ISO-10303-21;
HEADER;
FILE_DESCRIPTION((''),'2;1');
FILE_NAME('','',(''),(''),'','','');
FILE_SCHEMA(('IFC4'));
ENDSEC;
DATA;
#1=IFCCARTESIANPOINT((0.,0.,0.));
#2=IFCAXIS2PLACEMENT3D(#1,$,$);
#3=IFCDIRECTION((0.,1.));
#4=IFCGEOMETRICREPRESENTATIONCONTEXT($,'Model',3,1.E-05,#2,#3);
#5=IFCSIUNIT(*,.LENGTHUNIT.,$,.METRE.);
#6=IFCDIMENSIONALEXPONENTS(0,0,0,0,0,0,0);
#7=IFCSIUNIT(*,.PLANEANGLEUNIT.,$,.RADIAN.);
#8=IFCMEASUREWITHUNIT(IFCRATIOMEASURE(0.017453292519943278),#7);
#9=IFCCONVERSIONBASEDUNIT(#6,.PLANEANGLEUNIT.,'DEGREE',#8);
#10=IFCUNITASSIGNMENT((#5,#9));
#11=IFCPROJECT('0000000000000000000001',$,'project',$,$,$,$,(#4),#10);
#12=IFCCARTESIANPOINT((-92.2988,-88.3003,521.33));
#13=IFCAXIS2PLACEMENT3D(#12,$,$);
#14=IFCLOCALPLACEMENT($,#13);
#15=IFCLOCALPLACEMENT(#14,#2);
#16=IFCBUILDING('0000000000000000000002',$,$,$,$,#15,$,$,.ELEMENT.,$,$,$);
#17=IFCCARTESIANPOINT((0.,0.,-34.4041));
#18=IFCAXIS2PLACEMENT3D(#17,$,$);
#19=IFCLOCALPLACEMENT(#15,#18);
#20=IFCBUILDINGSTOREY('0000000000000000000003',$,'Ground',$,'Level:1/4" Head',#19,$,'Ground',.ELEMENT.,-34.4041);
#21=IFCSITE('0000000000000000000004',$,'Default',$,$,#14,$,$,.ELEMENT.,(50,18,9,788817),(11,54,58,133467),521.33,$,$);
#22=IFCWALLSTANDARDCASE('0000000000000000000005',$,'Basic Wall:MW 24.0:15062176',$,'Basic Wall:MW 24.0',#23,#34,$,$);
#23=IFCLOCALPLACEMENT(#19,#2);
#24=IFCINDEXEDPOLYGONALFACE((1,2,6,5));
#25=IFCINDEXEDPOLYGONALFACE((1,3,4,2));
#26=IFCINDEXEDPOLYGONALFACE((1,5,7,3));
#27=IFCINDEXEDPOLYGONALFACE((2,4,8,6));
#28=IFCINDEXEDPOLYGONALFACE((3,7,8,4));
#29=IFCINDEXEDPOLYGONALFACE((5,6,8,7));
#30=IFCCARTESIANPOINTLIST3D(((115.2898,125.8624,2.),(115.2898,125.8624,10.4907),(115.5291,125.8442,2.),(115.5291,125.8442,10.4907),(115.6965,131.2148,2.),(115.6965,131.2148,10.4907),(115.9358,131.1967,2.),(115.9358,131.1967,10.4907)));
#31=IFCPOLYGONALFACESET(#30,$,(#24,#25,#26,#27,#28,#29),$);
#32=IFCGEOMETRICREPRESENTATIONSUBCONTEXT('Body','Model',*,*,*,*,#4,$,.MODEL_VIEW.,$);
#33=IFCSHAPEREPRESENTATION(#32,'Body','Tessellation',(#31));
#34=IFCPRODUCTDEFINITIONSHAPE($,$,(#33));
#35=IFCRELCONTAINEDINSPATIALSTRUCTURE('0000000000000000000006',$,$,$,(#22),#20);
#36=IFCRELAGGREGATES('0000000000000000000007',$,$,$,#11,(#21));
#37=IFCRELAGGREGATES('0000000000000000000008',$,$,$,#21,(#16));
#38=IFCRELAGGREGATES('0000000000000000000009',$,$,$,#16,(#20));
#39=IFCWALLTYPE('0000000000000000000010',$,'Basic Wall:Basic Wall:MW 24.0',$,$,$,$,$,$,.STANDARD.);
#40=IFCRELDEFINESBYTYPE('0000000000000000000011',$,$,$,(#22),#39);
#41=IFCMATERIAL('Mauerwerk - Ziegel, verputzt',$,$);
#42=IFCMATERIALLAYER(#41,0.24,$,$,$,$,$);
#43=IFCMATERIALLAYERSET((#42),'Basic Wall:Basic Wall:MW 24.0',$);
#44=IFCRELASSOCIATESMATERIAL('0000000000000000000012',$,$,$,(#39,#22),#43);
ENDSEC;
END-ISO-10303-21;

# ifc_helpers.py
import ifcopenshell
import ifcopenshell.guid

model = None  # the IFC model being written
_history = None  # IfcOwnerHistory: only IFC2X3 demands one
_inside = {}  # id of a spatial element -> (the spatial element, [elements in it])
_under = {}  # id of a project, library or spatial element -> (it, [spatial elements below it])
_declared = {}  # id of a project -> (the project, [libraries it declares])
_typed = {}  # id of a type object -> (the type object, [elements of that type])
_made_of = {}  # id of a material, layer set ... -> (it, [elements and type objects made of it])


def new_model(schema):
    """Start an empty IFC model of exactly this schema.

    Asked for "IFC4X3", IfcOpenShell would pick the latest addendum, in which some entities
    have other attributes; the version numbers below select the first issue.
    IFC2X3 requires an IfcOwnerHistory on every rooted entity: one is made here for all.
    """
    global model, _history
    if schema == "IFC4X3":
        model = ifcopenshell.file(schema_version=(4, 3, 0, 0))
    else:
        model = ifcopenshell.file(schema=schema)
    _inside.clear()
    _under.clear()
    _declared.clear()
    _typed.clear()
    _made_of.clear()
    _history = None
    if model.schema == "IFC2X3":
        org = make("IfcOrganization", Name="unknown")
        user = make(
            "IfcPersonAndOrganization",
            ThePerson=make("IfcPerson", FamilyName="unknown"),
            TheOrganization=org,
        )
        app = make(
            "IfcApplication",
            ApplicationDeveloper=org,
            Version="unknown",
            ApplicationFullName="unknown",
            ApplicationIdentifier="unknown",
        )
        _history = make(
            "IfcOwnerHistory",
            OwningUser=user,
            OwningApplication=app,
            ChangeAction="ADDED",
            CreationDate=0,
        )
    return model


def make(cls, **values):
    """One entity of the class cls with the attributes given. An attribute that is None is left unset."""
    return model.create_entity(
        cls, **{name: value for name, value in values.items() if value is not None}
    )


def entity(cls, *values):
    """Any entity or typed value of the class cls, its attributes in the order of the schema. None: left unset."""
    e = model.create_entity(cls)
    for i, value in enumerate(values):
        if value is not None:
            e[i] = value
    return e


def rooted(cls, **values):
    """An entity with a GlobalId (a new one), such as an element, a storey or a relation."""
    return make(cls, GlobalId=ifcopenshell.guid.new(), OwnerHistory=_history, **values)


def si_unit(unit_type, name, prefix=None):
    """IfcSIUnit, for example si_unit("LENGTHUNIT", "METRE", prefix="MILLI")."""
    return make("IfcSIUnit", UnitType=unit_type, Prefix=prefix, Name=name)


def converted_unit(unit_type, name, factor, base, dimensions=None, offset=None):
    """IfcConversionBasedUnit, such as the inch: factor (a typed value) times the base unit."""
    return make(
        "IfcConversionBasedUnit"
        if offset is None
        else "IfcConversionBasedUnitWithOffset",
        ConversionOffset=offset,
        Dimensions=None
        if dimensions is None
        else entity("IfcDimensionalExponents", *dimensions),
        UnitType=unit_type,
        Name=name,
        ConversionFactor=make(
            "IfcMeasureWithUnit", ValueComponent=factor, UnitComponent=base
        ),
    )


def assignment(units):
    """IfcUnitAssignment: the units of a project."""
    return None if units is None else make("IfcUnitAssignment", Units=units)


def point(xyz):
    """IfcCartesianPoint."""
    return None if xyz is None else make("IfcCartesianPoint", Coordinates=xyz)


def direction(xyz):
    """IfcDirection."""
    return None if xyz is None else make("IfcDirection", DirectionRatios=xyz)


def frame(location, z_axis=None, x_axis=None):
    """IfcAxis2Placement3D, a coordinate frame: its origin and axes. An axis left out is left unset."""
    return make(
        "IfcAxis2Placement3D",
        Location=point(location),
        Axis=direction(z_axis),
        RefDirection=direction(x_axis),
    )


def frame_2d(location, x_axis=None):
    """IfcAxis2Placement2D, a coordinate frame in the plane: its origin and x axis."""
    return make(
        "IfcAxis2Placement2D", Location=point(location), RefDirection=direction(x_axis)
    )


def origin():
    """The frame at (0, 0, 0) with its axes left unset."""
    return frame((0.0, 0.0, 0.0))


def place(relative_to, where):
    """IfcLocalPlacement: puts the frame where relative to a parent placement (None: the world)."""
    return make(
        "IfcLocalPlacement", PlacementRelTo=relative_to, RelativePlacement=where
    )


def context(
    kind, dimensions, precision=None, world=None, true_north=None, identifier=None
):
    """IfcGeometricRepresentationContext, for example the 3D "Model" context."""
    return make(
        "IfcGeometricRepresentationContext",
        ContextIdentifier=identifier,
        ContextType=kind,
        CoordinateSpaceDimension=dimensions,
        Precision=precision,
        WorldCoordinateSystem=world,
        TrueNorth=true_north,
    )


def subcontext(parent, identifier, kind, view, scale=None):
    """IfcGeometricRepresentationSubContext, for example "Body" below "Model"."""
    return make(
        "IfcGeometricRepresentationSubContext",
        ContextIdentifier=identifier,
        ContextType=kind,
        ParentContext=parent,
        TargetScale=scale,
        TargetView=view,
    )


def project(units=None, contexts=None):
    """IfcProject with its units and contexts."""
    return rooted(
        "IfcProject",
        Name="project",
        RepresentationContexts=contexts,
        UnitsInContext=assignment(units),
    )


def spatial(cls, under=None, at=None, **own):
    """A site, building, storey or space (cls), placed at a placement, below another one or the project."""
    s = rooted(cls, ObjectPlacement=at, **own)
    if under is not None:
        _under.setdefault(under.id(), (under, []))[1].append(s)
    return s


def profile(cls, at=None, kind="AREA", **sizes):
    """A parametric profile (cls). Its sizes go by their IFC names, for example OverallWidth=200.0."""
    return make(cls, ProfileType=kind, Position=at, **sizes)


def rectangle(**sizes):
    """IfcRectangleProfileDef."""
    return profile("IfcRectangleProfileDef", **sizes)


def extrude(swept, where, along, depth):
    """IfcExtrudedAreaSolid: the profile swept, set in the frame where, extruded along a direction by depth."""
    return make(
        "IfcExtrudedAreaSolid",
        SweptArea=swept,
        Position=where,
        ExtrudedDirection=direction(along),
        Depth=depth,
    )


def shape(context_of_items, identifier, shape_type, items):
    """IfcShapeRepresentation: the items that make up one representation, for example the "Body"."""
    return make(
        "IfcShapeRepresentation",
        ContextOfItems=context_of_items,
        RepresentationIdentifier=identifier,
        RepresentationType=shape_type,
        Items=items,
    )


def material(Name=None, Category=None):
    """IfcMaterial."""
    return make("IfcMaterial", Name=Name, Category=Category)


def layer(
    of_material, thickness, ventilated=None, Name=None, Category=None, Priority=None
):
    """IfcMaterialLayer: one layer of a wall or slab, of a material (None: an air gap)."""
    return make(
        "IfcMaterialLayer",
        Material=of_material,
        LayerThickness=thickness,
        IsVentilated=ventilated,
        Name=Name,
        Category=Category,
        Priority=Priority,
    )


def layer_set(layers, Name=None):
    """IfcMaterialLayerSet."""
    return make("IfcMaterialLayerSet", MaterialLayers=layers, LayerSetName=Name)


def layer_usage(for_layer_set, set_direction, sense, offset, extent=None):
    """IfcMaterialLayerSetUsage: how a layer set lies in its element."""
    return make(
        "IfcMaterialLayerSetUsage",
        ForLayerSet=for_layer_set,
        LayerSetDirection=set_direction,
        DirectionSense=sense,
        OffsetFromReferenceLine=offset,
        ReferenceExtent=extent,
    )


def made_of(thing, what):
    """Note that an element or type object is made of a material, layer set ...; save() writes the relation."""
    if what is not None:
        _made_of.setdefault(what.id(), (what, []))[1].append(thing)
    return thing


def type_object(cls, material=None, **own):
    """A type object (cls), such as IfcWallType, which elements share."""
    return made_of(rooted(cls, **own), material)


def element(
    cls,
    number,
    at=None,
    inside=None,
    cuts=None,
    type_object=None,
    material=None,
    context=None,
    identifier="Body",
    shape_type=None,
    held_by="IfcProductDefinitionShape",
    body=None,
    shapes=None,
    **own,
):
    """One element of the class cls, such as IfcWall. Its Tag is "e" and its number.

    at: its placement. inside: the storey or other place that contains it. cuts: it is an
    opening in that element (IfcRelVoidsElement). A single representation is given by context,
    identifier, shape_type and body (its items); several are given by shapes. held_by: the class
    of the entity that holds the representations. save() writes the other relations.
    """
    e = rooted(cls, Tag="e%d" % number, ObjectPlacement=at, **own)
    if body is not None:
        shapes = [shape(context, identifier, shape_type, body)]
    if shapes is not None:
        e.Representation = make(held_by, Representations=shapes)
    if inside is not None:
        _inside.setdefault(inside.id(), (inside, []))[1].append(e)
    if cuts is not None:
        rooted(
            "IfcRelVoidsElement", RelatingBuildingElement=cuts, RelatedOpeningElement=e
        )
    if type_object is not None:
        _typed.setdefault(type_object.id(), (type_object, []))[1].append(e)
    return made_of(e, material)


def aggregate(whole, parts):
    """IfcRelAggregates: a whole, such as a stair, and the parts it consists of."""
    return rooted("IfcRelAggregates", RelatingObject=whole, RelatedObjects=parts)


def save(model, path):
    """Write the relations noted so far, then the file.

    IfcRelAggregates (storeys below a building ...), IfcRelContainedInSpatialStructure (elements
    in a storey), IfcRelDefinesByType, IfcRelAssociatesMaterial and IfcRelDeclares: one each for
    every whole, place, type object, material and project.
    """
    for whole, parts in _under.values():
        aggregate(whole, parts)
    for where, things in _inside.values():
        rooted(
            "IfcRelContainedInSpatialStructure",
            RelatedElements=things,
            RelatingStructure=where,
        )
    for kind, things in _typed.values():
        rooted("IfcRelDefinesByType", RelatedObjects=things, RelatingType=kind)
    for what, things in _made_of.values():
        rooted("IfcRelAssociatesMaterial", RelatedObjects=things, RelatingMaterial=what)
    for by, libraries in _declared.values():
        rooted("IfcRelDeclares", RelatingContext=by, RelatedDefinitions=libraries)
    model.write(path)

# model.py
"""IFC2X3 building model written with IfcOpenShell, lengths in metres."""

from ifc_helpers import new_model, entity, si_unit, converted_unit, direction, frame, frame_2d, origin, place, context, subcontext, project, spatial, rectangle, extrude, material, layer, layer_set, layer_usage, type_object, element, save


model = new_model("IFC2X3")

# Units and contexts
model_context = context("Model", 3, precision=1e-05, world=origin(), true_north=direction((0.0, 1.0)))
body_context = subcontext(model_context, "Body", "Model", "MODEL_VIEW")
ifc_project = project(units=[si_unit("LENGTHUNIT", "METRE"), converted_unit("PLANEANGLEUNIT", "DEGREE", entity("IfcRatioMeasure", 0.017453292519943278), si_unit("PLANEANGLEUNIT", "RADIAN"), dimensions=[0, 0, 0, 0, 0, 0, 0])], contexts=[model_context])

# Site, building, storey
site_placement = place(None, frame((-92.2988, -88.3003, 521.33)))
site = spatial("IfcSite", under=ifc_project, at=site_placement, Name="Default", CompositionType="ELEMENT", RefLatitude=(50, 18, 9, 788817), RefLongitude=(11, 54, 58, 133467), RefElevation=521.33)
building_placement = place(site_placement, origin())
building = spatial("IfcBuilding", under=site, at=building_placement, CompositionType="ELEMENT")
storey_placement = place(building_placement, frame((0.0, 0.0, -34.4041)))
storey = spatial("IfcBuildingStorey", under=building, at=storey_placement, Name="Ground", ObjectType="Level:1/4\" Head", LongName="Ground", CompositionType="ELEMENT", Elevation=-34.4041)

# Wall
ifc_material_1 = material(Name="Mauerwerk - Ziegel, verputzt")
ifc_layer_1 = layer(ifc_material_1, 0.24)
ifc_layer_set_1 = layer_set([ifc_layer_1], Name="Basic Wall:Basic Wall:MW 24.0")
wall_type_1 = type_object("IfcWallType", Name="Basic Wall:Basic Wall:MW 24.0", PredefinedType="STANDARD", material=ifc_layer_set_1)
ifc_layer_usage_1 = layer_usage(ifc_layer_set_1, "AXIS2", "NEGATIVE", 0.12)
wall_1_placement = place(storey_placement, frame((115.8162, 131.2057, 2.0), z_axis=(0.0, 0.0, 1.0), x_axis=(-0.07577, -0.997125, 0.0)))
element("IfcWallStandardCase", 1, at=wall_1_placement, inside=storey, type_object=wall_type_1, material=ifc_layer_usage_1, Name="Basic Wall:MW 24.0:15062176", ObjectType="Basic Wall:MW 24.0", context=body_context, shape_type="SweptSolid", body=[
    extrude(rectangle(XDim=5.3679, YDim=0.24, at=frame_2d((2.6839, 0.0), x_axis=(-1.0, 0.0))), origin(), (0.0, 0.0, 1.0), 8.4907),
])

save(model, "model.ifc")
